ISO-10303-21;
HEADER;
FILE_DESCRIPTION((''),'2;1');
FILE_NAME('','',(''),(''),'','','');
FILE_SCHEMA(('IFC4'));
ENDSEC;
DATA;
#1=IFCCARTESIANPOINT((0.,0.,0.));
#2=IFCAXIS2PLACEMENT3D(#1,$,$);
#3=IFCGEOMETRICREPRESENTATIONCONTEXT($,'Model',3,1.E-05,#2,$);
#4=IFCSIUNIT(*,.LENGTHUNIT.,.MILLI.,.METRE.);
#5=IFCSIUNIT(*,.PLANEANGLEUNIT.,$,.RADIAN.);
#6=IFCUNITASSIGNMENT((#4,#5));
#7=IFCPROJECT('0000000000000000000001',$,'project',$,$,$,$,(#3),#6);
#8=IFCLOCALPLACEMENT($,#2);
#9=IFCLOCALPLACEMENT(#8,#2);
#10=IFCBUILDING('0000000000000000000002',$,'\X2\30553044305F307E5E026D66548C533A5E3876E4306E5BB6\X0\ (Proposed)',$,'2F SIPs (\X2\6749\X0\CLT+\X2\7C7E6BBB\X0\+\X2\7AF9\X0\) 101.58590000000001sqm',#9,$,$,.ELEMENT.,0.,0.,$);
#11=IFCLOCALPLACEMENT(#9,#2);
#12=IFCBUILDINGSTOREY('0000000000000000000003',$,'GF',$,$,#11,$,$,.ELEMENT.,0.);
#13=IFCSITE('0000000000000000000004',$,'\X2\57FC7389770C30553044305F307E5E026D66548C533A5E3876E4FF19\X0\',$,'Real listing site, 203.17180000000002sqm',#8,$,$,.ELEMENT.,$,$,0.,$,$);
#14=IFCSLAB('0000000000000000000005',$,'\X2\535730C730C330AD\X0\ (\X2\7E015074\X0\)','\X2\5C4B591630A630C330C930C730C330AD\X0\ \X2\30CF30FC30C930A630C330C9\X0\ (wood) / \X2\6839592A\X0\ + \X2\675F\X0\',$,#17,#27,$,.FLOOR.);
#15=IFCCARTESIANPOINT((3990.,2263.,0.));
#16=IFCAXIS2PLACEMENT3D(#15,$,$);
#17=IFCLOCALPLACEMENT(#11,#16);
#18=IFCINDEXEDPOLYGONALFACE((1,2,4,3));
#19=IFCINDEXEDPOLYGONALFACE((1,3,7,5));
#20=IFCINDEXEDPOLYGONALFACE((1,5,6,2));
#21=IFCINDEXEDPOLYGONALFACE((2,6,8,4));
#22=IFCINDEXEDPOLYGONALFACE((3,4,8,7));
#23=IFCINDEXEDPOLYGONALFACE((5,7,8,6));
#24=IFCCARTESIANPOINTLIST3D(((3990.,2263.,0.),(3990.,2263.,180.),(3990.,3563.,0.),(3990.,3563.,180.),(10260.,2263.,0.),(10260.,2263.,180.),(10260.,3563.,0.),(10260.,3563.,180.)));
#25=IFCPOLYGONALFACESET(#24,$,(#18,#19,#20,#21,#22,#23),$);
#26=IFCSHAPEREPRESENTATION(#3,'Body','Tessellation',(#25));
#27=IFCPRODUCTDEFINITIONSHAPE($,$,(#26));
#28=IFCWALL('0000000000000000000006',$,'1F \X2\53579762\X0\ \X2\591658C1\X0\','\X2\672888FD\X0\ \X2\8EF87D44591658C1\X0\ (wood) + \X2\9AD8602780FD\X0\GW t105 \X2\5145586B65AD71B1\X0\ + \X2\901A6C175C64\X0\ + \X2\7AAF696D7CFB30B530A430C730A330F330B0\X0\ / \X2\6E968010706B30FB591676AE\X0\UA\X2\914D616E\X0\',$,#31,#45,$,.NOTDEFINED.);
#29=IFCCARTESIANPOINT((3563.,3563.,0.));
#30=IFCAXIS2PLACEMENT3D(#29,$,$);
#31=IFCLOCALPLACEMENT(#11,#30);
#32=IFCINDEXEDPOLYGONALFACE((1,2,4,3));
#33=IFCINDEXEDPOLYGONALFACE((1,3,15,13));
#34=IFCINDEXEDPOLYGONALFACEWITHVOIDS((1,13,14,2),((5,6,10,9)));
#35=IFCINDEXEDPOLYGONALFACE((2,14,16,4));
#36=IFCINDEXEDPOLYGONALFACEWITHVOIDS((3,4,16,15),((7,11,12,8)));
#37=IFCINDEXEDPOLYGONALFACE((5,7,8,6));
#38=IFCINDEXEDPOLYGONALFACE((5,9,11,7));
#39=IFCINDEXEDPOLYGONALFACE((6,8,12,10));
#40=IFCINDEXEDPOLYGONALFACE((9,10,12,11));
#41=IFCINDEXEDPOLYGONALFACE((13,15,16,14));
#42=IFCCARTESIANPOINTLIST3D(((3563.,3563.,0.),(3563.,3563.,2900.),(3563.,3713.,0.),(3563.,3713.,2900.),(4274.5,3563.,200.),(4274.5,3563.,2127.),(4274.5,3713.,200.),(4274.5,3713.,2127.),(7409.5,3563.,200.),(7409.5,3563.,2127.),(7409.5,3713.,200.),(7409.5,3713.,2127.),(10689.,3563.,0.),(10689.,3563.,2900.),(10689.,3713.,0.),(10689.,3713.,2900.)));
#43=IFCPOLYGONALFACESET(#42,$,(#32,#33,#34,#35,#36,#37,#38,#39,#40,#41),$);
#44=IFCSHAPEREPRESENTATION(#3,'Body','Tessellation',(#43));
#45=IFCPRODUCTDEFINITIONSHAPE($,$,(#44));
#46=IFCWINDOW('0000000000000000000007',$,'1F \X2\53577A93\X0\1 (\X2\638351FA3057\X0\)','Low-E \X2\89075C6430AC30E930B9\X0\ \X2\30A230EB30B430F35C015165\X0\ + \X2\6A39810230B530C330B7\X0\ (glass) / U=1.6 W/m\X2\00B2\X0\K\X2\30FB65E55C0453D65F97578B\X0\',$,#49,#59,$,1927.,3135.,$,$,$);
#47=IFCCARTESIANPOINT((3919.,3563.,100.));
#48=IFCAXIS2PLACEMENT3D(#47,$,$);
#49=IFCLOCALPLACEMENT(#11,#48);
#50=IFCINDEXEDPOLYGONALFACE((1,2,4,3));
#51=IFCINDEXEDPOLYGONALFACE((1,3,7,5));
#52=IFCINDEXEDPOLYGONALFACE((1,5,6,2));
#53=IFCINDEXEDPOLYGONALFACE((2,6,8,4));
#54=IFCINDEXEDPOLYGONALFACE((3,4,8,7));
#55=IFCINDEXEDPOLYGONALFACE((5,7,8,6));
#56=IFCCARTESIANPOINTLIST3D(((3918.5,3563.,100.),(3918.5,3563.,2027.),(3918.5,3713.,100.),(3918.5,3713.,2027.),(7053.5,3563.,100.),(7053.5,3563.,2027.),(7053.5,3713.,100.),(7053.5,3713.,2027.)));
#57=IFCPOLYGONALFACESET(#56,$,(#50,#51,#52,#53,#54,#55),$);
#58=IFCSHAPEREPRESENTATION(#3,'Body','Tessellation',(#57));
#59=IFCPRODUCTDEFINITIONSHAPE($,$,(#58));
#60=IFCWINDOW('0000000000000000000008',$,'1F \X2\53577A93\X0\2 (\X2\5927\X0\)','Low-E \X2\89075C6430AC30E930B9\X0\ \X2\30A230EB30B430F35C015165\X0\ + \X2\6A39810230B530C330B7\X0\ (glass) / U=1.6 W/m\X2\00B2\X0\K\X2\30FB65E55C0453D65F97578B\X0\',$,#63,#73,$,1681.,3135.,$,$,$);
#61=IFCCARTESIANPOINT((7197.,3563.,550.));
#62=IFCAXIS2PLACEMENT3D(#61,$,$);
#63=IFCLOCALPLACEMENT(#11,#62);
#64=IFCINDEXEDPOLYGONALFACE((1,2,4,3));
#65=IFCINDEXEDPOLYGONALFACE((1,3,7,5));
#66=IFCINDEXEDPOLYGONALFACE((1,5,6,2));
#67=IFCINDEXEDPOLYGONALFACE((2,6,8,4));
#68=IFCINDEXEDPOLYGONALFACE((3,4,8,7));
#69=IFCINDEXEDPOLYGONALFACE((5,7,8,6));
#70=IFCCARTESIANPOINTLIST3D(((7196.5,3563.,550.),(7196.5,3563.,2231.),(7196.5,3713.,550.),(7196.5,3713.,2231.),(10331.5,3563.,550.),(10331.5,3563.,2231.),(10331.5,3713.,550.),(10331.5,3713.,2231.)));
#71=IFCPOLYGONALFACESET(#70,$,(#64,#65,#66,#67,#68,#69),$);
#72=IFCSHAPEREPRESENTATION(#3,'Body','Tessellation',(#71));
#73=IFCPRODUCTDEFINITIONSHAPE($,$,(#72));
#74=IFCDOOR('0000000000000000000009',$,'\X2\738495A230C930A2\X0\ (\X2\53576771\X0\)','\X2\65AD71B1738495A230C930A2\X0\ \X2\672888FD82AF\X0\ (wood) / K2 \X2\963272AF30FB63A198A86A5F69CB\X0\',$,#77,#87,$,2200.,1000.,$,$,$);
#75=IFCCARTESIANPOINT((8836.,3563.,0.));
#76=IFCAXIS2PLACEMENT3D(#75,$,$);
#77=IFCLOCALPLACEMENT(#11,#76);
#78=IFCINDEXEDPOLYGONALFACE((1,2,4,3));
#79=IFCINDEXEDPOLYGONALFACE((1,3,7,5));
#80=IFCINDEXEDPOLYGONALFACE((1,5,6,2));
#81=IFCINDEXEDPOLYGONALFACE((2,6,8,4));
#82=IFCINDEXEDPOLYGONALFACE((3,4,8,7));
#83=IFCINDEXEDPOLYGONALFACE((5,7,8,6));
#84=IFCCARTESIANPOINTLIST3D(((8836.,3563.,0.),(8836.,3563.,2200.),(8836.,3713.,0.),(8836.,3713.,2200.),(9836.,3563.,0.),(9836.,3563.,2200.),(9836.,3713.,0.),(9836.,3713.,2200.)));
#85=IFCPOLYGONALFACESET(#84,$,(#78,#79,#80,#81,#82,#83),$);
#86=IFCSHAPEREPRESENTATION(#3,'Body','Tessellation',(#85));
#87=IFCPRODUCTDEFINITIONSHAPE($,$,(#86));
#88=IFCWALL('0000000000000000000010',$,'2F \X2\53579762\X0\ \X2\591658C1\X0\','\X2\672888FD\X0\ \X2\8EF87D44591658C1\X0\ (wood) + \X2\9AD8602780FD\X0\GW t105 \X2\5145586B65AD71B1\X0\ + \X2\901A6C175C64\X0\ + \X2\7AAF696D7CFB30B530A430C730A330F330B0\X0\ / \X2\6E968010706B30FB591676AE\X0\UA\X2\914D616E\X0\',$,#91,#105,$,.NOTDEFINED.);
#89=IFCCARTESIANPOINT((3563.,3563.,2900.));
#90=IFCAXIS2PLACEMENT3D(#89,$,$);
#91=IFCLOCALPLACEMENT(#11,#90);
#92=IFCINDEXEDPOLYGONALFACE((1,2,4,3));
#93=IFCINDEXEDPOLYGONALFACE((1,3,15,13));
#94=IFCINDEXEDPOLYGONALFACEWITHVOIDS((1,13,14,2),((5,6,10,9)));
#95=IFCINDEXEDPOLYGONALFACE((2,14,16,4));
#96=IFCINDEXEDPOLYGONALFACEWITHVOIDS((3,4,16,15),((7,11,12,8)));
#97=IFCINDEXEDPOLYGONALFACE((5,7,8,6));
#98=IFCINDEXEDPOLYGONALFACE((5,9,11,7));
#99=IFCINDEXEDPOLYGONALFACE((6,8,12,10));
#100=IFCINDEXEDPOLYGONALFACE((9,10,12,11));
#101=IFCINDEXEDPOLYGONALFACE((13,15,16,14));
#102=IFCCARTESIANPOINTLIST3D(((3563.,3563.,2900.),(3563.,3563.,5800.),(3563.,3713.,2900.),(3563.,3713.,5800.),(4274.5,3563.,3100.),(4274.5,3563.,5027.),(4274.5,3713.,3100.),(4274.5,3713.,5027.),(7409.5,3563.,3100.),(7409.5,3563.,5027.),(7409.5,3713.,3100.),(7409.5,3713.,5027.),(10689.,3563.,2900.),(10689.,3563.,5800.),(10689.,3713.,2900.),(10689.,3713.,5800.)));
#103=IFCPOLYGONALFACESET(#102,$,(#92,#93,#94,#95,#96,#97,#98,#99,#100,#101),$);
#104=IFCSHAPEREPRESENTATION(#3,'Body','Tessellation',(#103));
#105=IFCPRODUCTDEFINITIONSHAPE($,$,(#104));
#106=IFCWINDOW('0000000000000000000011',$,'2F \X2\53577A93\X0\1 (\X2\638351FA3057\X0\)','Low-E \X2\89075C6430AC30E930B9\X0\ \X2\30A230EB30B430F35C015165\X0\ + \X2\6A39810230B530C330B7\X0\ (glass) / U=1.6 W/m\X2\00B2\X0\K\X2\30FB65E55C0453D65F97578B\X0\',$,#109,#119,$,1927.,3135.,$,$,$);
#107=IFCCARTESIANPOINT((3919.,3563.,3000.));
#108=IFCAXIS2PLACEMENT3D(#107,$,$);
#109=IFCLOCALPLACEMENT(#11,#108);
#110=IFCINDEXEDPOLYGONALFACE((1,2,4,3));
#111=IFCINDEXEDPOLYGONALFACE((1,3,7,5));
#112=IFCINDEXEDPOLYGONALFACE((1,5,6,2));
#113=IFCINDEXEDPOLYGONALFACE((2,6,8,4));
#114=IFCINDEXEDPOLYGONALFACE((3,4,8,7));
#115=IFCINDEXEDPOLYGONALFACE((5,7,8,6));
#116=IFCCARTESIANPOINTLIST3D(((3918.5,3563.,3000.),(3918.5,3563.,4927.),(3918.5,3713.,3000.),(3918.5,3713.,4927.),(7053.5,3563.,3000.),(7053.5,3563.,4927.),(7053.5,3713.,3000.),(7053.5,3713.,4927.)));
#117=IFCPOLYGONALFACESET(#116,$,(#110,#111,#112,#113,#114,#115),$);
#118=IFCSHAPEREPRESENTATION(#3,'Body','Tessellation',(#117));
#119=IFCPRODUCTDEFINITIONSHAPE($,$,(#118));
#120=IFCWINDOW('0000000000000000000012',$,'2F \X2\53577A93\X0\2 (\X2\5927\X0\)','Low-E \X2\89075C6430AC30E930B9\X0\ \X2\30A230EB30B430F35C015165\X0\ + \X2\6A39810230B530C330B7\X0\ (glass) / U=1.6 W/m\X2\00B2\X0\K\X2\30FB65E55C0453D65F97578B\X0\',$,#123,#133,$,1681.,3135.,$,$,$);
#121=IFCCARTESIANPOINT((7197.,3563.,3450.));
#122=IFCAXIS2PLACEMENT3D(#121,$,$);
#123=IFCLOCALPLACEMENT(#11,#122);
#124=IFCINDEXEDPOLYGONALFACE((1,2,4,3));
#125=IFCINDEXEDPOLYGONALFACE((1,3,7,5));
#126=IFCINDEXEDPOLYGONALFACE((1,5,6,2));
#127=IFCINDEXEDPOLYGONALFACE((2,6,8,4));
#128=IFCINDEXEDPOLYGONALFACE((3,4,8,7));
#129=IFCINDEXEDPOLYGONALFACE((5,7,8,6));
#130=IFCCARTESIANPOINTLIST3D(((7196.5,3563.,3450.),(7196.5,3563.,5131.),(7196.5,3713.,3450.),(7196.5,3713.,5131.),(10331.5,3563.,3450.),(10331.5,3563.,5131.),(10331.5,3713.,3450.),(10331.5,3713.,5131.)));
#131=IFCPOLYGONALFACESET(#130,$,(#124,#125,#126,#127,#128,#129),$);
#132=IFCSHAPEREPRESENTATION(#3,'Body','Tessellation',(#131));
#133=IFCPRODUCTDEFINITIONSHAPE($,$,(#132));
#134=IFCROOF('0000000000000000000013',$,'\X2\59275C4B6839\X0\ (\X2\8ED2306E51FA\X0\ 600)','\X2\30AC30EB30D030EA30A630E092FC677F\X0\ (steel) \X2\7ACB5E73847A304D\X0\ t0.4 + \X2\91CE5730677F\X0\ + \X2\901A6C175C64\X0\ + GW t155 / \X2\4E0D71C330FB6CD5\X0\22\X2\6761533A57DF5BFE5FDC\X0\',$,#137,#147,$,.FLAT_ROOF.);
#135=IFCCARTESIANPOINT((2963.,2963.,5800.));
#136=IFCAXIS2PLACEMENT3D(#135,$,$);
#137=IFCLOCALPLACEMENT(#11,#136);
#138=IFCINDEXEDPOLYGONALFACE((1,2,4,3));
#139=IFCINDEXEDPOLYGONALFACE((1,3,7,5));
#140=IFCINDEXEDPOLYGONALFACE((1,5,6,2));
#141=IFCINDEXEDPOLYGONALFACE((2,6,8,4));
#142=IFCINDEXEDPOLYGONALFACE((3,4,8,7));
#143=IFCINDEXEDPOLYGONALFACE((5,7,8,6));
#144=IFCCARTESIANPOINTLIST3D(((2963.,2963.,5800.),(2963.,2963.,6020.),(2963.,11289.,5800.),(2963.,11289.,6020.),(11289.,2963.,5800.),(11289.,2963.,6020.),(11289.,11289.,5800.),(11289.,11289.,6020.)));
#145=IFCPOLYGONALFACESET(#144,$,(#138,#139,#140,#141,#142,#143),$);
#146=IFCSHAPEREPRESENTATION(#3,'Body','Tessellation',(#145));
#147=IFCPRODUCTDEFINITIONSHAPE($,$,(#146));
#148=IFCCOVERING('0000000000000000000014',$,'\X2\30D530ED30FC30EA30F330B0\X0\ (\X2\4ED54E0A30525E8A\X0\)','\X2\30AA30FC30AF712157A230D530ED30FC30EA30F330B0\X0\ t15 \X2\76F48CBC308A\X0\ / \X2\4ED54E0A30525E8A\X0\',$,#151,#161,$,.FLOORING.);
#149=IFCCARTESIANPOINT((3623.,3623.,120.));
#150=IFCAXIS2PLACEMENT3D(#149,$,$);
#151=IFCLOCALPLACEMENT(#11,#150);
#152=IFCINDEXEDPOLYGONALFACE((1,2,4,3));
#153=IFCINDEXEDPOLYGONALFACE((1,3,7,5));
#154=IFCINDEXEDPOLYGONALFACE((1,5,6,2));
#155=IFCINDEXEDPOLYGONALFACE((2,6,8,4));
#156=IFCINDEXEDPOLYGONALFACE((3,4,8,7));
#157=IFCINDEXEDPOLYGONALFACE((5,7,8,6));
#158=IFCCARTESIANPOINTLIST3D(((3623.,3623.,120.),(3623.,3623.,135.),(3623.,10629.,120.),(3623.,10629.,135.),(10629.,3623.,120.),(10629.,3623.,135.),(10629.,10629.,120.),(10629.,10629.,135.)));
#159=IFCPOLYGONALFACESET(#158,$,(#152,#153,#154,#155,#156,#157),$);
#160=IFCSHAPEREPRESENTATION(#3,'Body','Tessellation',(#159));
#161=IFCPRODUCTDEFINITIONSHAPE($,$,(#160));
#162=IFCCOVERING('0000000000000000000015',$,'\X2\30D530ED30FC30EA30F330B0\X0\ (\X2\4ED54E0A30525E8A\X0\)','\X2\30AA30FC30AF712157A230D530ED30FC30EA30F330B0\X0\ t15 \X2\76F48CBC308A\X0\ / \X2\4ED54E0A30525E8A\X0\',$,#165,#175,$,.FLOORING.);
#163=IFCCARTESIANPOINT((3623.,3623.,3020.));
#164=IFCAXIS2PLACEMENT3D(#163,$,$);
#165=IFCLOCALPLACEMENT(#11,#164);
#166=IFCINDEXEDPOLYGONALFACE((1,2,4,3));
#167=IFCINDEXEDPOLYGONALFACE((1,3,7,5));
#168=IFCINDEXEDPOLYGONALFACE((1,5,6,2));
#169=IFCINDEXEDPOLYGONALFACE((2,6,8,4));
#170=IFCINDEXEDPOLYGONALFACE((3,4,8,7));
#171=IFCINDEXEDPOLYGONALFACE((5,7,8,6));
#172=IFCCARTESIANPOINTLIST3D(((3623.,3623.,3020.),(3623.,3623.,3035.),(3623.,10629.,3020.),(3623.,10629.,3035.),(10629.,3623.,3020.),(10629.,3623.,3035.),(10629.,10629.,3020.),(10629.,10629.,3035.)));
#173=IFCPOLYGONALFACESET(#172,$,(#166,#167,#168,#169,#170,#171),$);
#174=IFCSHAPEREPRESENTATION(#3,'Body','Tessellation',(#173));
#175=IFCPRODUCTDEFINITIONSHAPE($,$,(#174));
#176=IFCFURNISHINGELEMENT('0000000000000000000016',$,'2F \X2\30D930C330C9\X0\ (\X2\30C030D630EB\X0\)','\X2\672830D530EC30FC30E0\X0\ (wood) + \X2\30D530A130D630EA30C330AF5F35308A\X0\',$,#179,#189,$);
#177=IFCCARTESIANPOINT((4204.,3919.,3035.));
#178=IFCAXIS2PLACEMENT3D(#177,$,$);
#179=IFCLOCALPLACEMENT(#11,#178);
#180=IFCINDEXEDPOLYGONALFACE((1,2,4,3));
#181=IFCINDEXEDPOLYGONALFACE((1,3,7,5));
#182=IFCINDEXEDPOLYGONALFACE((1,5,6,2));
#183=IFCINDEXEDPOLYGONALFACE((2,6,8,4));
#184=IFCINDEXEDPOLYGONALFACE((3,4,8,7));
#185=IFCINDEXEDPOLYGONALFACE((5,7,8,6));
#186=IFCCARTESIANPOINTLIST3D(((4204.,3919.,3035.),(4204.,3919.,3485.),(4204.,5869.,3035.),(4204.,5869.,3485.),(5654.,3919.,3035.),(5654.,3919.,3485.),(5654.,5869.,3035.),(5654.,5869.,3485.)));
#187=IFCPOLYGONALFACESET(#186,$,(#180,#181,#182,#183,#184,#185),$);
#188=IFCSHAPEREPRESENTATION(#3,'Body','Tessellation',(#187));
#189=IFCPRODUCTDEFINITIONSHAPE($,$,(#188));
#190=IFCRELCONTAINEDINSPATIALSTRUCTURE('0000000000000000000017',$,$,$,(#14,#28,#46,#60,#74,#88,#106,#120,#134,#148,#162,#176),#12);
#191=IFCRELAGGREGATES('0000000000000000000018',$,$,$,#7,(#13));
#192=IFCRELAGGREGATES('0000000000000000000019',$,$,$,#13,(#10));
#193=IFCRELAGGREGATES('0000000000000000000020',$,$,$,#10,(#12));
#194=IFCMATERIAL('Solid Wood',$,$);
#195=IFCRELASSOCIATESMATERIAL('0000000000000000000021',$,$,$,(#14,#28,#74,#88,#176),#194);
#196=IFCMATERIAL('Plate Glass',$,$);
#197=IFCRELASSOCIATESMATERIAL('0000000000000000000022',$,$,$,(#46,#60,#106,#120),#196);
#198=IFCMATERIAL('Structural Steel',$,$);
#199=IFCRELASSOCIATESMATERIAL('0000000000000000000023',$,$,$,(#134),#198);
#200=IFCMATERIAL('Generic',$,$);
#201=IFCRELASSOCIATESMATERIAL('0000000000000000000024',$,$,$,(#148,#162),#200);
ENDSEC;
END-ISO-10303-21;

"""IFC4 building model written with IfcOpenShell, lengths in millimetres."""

from ifc_helpers import new_model, si_unit, frame, frame_2d, origin, place, context, project, spatial, rectangle, extrude, material, element, fill, save


model = new_model("IFC4")

# Units and contexts
model_context = context("Model", 3, precision=1e-05, world=origin())
ifc_project = project(units=[si_unit("LENGTHUNIT", "METRE", prefix="MILLI"), si_unit("PLANEANGLEUNIT", "RADIAN")], contexts=[model_context])

# Site, building, storey
site_placement = place(None, origin())
site = spatial("IfcSite", under=ifc_project, at=site_placement, Name="埼玉県さいたま市浦和区常盤９", ObjectType="Real listing site, 203.17180000000002sqm", CompositionType="ELEMENT", RefElevation=0.0)
building_placement = place(site_placement, origin())
building = spatial("IfcBuilding", under=site, at=building_placement, Name="さいたま市浦和区常盤の家 (Proposed)", ObjectType="2F SIPs (杉CLT+籾殻+竹) 101.58590000000001sqm", CompositionType="ELEMENT", ElevationOfRefHeight=0.0, ElevationOfTerrain=0.0)
storey_placement = place(building_placement, origin())
storey = spatial("IfcBuildingStorey", under=building, at=storey_placement, Name="GF", CompositionType="ELEMENT", Elevation=0.0)

# Slab
ifc_material_1 = material(Name="Solid Wood")
slab_1_placement = place(storey_placement, frame((3990.0, 2263.0, 0.0)))
element("IfcSlab", 1, at=slab_1_placement, inside=storey, material=ifc_material_1, Name="南デッキ (縁側)", Description="屋外ウッドデッキ ハードウッド (wood) / 根太 + 束", PredefinedType="FLOOR", context=model_context, shape_type="SweptSolid", body=[
    extrude(rectangle(XDim=6270.0, YDim=1300.0, at=frame_2d((3135.0, 650.0))), frame((3990.0, 2263.0, 0.0)), (0.0, 0.0, 1.0), 180.0),
])

# Wall, openings, windows, door
wall_1_placement = place(storey_placement, frame((3563.0, 3563.0, 0.0)))
wall_1 = element("IfcWall", 2, at=wall_1_placement, inside=storey, material=ifc_material_1, Name="1F 南面 外壁", Description="木製 軸組外壁 (wood) + 高性能GW t105 充填断熱 + 通気層 + 窯業系サイディング / 準耐火・外皮UA配慮", PredefinedType="NOTDEFINED", context=model_context, shape_type="SweptSolid", body=[
    extrude(rectangle(XDim=7126.0, YDim=150.0, at=frame_2d((3563.0, 75.0))), frame((3563.0, 3563.0, 0.0)), (0.0, 0.0, 1.0), 2900.0),
])
opening_1_placement = place(storey_placement, frame((3919.0, 3563.0, 100.0)))
opening_1 = element("IfcOpeningElement", 3, at=opening_1_placement, cuts=wall_1, PredefinedType="NOTDEFINED", context=model_context, shape_type="SweptSolid", body=[
    extrude(rectangle(XDim=3135.0, YDim=150.0, at=frame_2d((1567.0, 75.0))), frame((3919.0, 3563.0, 100.0)), (0.0, 0.0, 1.0), 1927.0),
])
opening_2_placement = place(storey_placement, frame((7197.0, 3563.0, 550.0)))
opening_2 = element("IfcOpeningElement", 4, at=opening_2_placement, cuts=wall_1, PredefinedType="NOTDEFINED", context=model_context, shape_type="SweptSolid", body=[
    extrude(rectangle(XDim=3135.0, YDim=150.0, at=frame_2d((1567.0, 75.0))), frame((7197.0, 3563.0, 550.0)), (0.0, 0.0, 1.0), 1681.0),
])
opening_3_placement = place(storey_placement, frame((8836.0, 3563.0, 0.0)))
opening_3 = element("IfcOpeningElement", 5, at=opening_3_placement, cuts=wall_1, PredefinedType="NOTDEFINED", context=model_context, shape_type="SweptSolid", body=[
    extrude(rectangle(XDim=1000.0, YDim=150.0, at=frame_2d((500.0, 75.0))), frame((8836.0, 3563.0, 0.0)), (0.0, 0.0, 1.0), 2200.0),
])
ifc_material_2 = material(Name="Plate Glass")
window_1_placement = place(storey_placement, frame((3919.0, 3563.0, 100.0)))
window_1 = element("IfcWindow", 6, at=window_1_placement, inside=storey, material=ifc_material_2, Name="1F 南窓1 (掃出し)", Description="Low-E 複層ガラス アルゴン封入 + 樹脂サッシ (glass) / U=1.6 W/m²K・日射取得型", OverallHeight=1927.0, OverallWidth=3135.0, context=model_context, shape_type="SweptSolid", body=[
    extrude(rectangle(XDim=3135.0, YDim=150.0, at=frame_2d((1567.0, 75.0))), frame((3919.0, 3563.0, 100.0)), (0.0, 0.0, 1.0), 1927.0),
])
fill(opening_1, window_1)
window_2_placement = place(storey_placement, frame((7197.0, 3563.0, 550.0)))
window_2 = element("IfcWindow", 7, at=window_2_placement, inside=storey, material=ifc_material_2, Name="1F 南窓2 (大)", Description="Low-E 複層ガラス アルゴン封入 + 樹脂サッシ (glass) / U=1.6 W/m²K・日射取得型", OverallHeight=1681.0, OverallWidth=3135.0, context=model_context, shape_type="SweptSolid", body=[
    extrude(rectangle(XDim=3135.0, YDim=150.0, at=frame_2d((1567.0, 75.0))), frame((7197.0, 3563.0, 550.0)), (0.0, 0.0, 1.0), 1681.0),
])
fill(opening_2, window_2)
door_placement = place(storey_placement, frame((8836.0, 3563.0, 0.0)))
door = element("IfcDoor", 8, at=door_placement, inside=storey, material=ifc_material_1, Name="玄関ドア (南東)", Description="断熱玄関ドア 木製芯 (wood) / K2 防犯・採風機構", OverallHeight=2200.0, OverallWidth=1000.0, context=model_context, shape_type="SweptSolid", body=[
    extrude(rectangle(XDim=1000.0, YDim=150.0, at=frame_2d((500.0, 75.0))), frame((8836.0, 3563.0, 0.0)), (0.0, 0.0, 1.0), 2200.0),
])
fill(opening_3, door)

# Wall, openings, windows
wall_2_placement = place(storey_placement, frame((3563.0, 3563.0, 2900.0)))
wall_2 = element("IfcWall", 9, at=wall_2_placement, inside=storey, material=ifc_material_1, Name="2F 南面 外壁", Description="木製 軸組外壁 (wood) + 高性能GW t105 充填断熱 + 通気層 + 窯業系サイディング / 準耐火・外皮UA配慮", PredefinedType="NOTDEFINED", context=model_context, shape_type="SweptSolid", body=[
    extrude(rectangle(XDim=7126.0, YDim=150.0, at=frame_2d((3563.0, 75.0))), frame((3563.0, 3563.0, 2900.0)), (0.0, 0.0, 1.0), 2900.0),
])
opening_4_placement = place(storey_placement, frame((3919.0, 3563.0, 3000.0)))
opening_4 = element("IfcOpeningElement", 10, at=opening_4_placement, cuts=wall_2, PredefinedType="NOTDEFINED", context=model_context, shape_type="SweptSolid", body=[
    extrude(rectangle(XDim=3135.0, YDim=150.0, at=frame_2d((1567.0, 75.0))), frame((3919.0, 3563.0, 3000.0)), (0.0, 0.0, 1.0), 1927.0),
])
opening_5_placement = place(storey_placement, frame((7197.0, 3563.0, 3450.0)))
opening_5 = element("IfcOpeningElement", 11, at=opening_5_placement, cuts=wall_2, PredefinedType="NOTDEFINED", context=model_context, shape_type="SweptSolid", body=[
    extrude(rectangle(XDim=3135.0, YDim=150.0, at=frame_2d((1567.0, 75.0))), frame((7197.0, 3563.0, 3450.0)), (0.0, 0.0, 1.0), 1681.0),
])
window_3_placement = place(storey_placement, frame((3919.0, 3563.0, 3000.0)))
window_3 = element("IfcWindow", 12, at=window_3_placement, inside=storey, material=ifc_material_2, Name="2F 南窓1 (掃出し)", Description="Low-E 複層ガラス アルゴン封入 + 樹脂サッシ (glass) / U=1.6 W/m²K・日射取得型", OverallHeight=1927.0, OverallWidth=3135.0, context=model_context, shape_type="SweptSolid", body=[
    extrude(rectangle(XDim=3135.0, YDim=150.0, at=frame_2d((1567.0, 75.0))), frame((3919.0, 3563.0, 3000.0)), (0.0, 0.0, 1.0), 1927.0),
])
fill(opening_4, window_3)
window_4_placement = place(storey_placement, frame((7197.0, 3563.0, 3450.0)))
window_4 = element("IfcWindow", 13, at=window_4_placement, inside=storey, material=ifc_material_2, Name="2F 南窓2 (大)", Description="Low-E 複層ガラス アルゴン封入 + 樹脂サッシ (glass) / U=1.6 W/m²K・日射取得型", OverallHeight=1681.0, OverallWidth=3135.0, context=model_context, shape_type="SweptSolid", body=[
    extrude(rectangle(XDim=3135.0, YDim=150.0, at=frame_2d((1567.0, 75.0))), frame((7197.0, 3563.0, 3450.0)), (0.0, 0.0, 1.0), 1681.0),
])
fill(opening_5, window_4)

# Roof
ifc_material_3 = material(Name="Structural Steel")
roof_placement = place(storey_placement, frame((2963.0, 2963.0, 5800.0)))
element("IfcRoof", 14, at=roof_placement, inside=storey, material=ifc_material_3, Name="大屋根 (軒の出 600)", Description="ガルバリウム鋼板 (steel) 立平葺き t0.4 + 野地板 + 通気層 + GW t155 / 不燃・法22条区域対応", PredefinedType="FLAT_ROOF", context=model_context, shape_type="SweptSolid", body=[
    extrude(rectangle(XDim=8326.0, YDim=8326.0, at=frame_2d((4163.0, 4163.0))), frame((2963.0, 2963.0, 5800.0)), (0.0, 0.0, 1.0), 220.0),
])

# Coverings
ifc_material_4 = material(Name="Generic")
covering_1_placement = place(storey_placement, frame((3623.0, 3623.0, 120.0)))
element("IfcCovering", 15, at=covering_1_placement, inside=storey, material=ifc_material_4, Name="フローリング (仕上げ床)", Description="オーク無垢フローリング t15 直貼り / 仕上げ床", PredefinedType="FLOORING", context=model_context, shape_type="SweptSolid", body=[
    extrude(rectangle(XDim=7006.0, YDim=7006.0, at=frame_2d((3503.0, 3503.0))), frame((3623.0, 3623.0, 120.0)), (0.0, 0.0, 1.0), 15.0),
])
covering_2_placement = place(storey_placement, frame((3623.0, 3623.0, 3020.0)))
element("IfcCovering", 16, at=covering_2_placement, inside=storey, material=ifc_material_4, Name="フローリング (仕上げ床)", Description="オーク無垢フローリング t15 直貼り / 仕上げ床", PredefinedType="FLOORING", context=model_context, shape_type="SweptSolid", body=[
    extrude(rectangle(XDim=7006.0, YDim=7006.0, at=frame_2d((3503.0, 3503.0))), frame((3623.0, 3623.0, 3020.0)), (0.0, 0.0, 1.0), 15.0),
])

# Furnishing element
furnishing_placement = place(storey_placement, frame((4204.0, 3919.0, 3035.0)))
element("IfcFurnishingElement", 17, at=furnishing_placement, inside=storey, material=ifc_material_1, Name="2F ベッド (ダブル)", Description="木フレーム (wood) + ファブリック張り", context=model_context, shape_type="SweptSolid", body=[
    extrude(rectangle(XDim=1450.0, YDim=1950.0, at=frame_2d((725.0, 975.0))), frame((4204.0, 3919.0, 3035.0)), (0.0, 0.0, 1.0), 450.0),
])

save(model, "model.ifc")
